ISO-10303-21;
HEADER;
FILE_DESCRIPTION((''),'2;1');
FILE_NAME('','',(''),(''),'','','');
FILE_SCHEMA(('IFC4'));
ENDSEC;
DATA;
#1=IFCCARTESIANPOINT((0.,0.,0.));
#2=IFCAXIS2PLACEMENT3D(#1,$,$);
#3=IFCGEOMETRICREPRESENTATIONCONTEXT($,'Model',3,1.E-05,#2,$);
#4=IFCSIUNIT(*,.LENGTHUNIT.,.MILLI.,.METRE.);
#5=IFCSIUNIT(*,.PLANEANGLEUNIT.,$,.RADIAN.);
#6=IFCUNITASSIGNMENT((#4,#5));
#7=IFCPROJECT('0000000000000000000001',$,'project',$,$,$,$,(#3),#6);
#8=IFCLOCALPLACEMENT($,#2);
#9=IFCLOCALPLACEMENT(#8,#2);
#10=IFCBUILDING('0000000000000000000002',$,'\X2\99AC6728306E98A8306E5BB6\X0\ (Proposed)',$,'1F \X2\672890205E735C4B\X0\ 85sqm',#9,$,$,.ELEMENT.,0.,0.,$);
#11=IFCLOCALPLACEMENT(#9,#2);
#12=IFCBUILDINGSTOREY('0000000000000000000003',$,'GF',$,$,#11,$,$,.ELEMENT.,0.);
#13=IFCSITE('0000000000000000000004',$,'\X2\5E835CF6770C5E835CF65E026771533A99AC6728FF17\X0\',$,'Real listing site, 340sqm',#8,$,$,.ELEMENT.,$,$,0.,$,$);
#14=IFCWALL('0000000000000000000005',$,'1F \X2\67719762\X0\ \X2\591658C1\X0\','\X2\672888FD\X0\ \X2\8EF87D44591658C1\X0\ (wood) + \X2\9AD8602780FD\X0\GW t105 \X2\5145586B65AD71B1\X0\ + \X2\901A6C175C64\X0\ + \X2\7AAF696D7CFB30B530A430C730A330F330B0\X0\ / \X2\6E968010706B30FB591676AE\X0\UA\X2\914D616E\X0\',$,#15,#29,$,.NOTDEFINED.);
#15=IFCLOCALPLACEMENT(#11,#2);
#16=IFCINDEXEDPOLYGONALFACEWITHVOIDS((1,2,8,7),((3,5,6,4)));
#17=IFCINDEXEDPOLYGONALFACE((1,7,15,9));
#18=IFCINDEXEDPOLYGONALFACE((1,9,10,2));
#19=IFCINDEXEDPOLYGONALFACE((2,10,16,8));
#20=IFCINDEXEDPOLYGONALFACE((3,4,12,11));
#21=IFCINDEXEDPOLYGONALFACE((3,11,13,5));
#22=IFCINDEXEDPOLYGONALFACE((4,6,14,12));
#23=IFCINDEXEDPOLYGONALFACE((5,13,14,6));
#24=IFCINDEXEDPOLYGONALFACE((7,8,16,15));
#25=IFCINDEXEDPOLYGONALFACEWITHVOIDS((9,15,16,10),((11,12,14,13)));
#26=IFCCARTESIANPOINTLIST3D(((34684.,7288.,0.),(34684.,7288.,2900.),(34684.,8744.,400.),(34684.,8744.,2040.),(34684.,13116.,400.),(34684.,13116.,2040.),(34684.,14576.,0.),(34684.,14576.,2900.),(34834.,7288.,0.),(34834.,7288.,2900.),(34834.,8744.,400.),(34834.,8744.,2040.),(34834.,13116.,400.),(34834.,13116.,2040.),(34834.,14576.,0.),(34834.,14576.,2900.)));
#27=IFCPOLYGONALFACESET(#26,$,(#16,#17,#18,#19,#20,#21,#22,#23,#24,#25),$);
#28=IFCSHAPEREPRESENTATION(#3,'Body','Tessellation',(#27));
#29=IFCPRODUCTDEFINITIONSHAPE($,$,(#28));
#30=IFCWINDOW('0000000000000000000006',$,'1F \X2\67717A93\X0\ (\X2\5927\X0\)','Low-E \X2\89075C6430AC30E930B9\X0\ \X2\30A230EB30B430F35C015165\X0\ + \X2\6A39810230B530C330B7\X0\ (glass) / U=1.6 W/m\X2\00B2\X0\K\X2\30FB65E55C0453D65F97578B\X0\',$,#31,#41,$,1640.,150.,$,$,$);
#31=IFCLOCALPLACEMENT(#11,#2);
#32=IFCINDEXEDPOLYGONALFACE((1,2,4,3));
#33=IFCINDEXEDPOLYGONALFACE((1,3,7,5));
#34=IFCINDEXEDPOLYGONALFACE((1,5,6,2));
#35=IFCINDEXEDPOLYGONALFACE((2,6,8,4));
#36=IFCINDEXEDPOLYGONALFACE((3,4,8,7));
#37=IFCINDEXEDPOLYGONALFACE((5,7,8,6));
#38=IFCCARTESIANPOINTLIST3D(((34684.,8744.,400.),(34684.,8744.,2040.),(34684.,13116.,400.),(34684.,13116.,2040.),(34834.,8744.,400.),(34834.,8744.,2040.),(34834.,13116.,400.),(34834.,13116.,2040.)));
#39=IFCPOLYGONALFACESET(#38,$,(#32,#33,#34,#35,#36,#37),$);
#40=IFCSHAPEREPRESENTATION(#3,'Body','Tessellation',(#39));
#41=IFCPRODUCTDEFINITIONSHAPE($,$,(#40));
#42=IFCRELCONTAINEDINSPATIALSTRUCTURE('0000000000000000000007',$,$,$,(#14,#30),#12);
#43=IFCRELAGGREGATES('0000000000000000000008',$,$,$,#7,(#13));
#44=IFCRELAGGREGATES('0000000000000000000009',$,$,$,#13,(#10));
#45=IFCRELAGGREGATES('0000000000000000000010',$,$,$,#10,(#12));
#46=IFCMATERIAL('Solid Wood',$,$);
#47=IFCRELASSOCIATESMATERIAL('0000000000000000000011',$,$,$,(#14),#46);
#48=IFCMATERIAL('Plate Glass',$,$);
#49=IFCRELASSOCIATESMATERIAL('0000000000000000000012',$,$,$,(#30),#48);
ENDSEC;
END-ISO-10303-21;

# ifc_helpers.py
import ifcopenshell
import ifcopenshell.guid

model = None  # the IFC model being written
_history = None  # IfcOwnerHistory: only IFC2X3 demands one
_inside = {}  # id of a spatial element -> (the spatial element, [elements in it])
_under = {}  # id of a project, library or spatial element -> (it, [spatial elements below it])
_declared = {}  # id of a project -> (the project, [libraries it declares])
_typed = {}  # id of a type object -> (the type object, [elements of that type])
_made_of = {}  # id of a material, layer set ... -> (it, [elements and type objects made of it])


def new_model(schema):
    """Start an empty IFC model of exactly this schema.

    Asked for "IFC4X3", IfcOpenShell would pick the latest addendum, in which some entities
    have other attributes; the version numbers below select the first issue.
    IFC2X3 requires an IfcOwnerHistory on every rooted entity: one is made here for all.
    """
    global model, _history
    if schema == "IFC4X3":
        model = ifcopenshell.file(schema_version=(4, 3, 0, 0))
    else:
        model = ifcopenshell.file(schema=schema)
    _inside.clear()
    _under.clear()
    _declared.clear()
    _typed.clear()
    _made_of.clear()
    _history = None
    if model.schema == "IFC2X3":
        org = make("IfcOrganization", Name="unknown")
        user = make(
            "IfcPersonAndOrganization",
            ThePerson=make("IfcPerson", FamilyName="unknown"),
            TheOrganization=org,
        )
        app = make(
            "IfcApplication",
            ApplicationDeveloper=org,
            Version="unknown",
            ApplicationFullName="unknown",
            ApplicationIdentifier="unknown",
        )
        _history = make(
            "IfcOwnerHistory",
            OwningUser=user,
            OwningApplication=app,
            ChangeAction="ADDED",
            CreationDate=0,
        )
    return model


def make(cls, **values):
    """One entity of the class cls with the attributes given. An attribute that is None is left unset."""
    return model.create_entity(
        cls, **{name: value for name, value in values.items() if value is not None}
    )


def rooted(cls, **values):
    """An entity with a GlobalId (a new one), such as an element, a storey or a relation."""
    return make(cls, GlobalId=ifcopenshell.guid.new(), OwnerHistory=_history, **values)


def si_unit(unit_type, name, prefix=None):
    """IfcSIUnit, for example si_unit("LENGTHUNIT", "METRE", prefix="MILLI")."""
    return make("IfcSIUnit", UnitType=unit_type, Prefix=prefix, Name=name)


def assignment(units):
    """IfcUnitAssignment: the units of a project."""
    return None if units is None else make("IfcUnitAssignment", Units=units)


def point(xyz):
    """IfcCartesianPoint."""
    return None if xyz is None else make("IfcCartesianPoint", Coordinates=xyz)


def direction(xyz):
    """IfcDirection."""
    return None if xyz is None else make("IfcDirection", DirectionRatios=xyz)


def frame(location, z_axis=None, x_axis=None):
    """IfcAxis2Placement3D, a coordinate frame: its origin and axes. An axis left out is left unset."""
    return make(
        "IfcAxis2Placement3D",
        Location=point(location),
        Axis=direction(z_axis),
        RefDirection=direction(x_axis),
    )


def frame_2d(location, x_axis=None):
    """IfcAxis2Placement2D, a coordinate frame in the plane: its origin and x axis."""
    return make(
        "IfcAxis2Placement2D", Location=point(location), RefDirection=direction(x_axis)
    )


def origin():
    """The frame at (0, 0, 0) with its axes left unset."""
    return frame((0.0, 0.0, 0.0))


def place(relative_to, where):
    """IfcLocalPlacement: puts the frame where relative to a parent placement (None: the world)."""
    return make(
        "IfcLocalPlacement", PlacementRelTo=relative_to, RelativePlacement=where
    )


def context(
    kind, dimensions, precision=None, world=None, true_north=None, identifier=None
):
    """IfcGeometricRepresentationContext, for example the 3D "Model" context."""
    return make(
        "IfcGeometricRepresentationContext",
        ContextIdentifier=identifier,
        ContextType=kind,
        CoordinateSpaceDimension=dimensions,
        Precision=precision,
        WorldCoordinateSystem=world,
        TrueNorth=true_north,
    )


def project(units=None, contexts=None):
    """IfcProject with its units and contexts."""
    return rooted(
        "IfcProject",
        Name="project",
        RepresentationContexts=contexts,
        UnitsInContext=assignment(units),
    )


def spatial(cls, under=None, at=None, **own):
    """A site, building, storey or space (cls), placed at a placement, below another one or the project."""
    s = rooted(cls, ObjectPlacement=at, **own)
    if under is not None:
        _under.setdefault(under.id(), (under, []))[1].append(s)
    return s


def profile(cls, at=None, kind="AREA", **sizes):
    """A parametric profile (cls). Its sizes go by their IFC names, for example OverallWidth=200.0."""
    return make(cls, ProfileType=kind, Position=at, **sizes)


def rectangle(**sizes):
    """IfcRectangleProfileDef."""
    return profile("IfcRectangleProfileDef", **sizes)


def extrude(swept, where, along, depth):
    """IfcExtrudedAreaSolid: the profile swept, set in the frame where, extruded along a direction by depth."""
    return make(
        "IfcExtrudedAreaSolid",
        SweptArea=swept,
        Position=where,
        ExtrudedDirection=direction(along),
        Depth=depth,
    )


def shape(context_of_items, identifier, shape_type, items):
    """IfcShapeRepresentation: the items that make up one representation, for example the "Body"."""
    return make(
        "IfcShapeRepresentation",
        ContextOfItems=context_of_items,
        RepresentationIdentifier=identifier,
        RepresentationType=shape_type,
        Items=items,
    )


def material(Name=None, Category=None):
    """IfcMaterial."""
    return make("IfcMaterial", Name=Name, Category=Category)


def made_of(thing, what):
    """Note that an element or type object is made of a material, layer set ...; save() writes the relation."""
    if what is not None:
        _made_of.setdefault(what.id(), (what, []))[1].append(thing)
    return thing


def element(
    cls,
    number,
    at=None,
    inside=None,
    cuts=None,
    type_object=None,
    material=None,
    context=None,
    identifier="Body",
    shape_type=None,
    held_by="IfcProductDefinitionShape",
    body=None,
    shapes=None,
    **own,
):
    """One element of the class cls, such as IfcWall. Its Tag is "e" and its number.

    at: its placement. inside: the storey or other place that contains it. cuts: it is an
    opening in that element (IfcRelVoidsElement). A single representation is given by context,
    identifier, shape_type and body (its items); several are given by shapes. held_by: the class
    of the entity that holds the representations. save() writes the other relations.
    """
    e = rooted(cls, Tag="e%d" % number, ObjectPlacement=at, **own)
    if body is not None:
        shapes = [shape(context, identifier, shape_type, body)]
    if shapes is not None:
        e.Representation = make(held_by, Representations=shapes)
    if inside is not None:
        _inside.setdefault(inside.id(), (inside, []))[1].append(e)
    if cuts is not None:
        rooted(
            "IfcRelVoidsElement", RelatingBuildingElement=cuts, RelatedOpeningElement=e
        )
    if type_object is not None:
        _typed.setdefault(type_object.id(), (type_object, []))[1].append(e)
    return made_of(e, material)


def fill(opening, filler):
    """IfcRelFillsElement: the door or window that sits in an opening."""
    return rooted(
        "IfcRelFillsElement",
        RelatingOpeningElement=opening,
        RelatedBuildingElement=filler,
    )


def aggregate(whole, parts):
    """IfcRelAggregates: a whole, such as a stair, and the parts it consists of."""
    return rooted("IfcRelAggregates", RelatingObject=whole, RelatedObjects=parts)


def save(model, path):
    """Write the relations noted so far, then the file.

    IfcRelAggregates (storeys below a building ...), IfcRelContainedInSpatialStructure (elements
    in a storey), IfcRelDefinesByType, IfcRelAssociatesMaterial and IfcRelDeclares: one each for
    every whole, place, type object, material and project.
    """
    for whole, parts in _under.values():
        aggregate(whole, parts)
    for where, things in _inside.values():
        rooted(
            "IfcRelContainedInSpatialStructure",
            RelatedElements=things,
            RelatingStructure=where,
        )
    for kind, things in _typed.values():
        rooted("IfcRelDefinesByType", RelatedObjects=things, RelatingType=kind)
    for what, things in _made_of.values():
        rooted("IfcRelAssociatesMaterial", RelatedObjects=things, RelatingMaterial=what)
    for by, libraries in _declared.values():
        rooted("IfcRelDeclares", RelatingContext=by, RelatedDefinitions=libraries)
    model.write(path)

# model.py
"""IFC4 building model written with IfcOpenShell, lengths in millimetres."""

from ifc_helpers import new_model, si_unit, frame, frame_2d, origin, place, context, project, spatial, rectangle, extrude, material, element, fill, save


model = new_model("IFC4")

# Units and contexts
model_context = context("Model", 3, precision=1e-05, world=origin())
ifc_project = project(units=[si_unit("LENGTHUNIT", "METRE", prefix="MILLI"), si_unit("PLANEANGLEUNIT", "RADIAN")], contexts=[model_context])

# Site, building, storey
site_placement = place(None, origin())
site = spatial("IfcSite", under=ifc_project, at=site_placement, Name="広島県広島市東区馬木７", ObjectType="Real listing site, 340sqm", CompositionType="ELEMENT", RefElevation=0.0)
building_placement = place(site_placement, origin())
building = spatial("IfcBuilding", under=site, at=building_placement, Name="馬木の風の家 (Proposed)", ObjectType="1F 木造平屋 85sqm", CompositionType="ELEMENT", ElevationOfRefHeight=0.0, ElevationOfTerrain=0.0)
storey_placement = place(building_placement, origin())
storey = spatial("IfcBuildingStorey", under=building, at=storey_placement, Name="GF", CompositionType="ELEMENT", Elevation=0.0)

# Shared definitions
ifc_material_1 = material(Name="Solid Wood")

# Wall, opening, window
wall_1_placement = place(storey_placement, frame((17342.0, 3644.0, 0.0)))
wall_1 = element("IfcWall", 1, at=wall_1_placement, inside=storey, material=ifc_material_1, Name="1F 東面 外壁", Description="木製 軸組外壁 (wood) + 高性能GW t105 充填断熱 + 通気層 + 窯業系サイディング / 準耐火・外皮UA配慮", PredefinedType="NOTDEFINED", context=model_context, shape_type="SweptSolid", body=[
    extrude(rectangle(XDim=150.0, YDim=7288.0, at=frame_2d((75.0, 3644.0))), frame((17342.0, 3644.0, 0.0)), (0.0, 0.0, 1.0), 2900.0),
])
opening_placement = place(storey_placement, frame((17342.0, 4372.0, 200.0)))
opening = element("IfcOpeningElement", 2, at=opening_placement, cuts=wall_1, PredefinedType="NOTDEFINED", context=model_context, shape_type="SweptSolid", body=[
    extrude(rectangle(XDim=150.0, YDim=4372.0, at=frame_2d((75.0, 2186.0))), frame((17342.0, 4372.0, 200.0)), (0.0, 0.0, 1.0), 1640.0),
])
ifc_material_2 = material(Name="Plate Glass")
window_1_placement = place(storey_placement, frame((17342.0, 4372.0, 200.0)))
window_1 = element("IfcWindow", 3, at=window_1_placement, inside=storey, material=ifc_material_2, Name="1F 東窓 (大)", Description="Low-E 複層ガラス アルゴン封入 + 樹脂サッシ (glass) / U=1.6 W/m²K・日射取得型", OverallHeight=1640.0, OverallWidth=150.0, context=model_context, shape_type="SweptSolid", body=[
    extrude(rectangle(XDim=150.0, YDim=4372.0, at=frame_2d((75.0, 2186.0))), frame((17342.0, 4372.0, 200.0)), (0.0, 0.0, 1.0), 1640.0),
])
fill(opening, window_1)

save(model, "model.ifc")
